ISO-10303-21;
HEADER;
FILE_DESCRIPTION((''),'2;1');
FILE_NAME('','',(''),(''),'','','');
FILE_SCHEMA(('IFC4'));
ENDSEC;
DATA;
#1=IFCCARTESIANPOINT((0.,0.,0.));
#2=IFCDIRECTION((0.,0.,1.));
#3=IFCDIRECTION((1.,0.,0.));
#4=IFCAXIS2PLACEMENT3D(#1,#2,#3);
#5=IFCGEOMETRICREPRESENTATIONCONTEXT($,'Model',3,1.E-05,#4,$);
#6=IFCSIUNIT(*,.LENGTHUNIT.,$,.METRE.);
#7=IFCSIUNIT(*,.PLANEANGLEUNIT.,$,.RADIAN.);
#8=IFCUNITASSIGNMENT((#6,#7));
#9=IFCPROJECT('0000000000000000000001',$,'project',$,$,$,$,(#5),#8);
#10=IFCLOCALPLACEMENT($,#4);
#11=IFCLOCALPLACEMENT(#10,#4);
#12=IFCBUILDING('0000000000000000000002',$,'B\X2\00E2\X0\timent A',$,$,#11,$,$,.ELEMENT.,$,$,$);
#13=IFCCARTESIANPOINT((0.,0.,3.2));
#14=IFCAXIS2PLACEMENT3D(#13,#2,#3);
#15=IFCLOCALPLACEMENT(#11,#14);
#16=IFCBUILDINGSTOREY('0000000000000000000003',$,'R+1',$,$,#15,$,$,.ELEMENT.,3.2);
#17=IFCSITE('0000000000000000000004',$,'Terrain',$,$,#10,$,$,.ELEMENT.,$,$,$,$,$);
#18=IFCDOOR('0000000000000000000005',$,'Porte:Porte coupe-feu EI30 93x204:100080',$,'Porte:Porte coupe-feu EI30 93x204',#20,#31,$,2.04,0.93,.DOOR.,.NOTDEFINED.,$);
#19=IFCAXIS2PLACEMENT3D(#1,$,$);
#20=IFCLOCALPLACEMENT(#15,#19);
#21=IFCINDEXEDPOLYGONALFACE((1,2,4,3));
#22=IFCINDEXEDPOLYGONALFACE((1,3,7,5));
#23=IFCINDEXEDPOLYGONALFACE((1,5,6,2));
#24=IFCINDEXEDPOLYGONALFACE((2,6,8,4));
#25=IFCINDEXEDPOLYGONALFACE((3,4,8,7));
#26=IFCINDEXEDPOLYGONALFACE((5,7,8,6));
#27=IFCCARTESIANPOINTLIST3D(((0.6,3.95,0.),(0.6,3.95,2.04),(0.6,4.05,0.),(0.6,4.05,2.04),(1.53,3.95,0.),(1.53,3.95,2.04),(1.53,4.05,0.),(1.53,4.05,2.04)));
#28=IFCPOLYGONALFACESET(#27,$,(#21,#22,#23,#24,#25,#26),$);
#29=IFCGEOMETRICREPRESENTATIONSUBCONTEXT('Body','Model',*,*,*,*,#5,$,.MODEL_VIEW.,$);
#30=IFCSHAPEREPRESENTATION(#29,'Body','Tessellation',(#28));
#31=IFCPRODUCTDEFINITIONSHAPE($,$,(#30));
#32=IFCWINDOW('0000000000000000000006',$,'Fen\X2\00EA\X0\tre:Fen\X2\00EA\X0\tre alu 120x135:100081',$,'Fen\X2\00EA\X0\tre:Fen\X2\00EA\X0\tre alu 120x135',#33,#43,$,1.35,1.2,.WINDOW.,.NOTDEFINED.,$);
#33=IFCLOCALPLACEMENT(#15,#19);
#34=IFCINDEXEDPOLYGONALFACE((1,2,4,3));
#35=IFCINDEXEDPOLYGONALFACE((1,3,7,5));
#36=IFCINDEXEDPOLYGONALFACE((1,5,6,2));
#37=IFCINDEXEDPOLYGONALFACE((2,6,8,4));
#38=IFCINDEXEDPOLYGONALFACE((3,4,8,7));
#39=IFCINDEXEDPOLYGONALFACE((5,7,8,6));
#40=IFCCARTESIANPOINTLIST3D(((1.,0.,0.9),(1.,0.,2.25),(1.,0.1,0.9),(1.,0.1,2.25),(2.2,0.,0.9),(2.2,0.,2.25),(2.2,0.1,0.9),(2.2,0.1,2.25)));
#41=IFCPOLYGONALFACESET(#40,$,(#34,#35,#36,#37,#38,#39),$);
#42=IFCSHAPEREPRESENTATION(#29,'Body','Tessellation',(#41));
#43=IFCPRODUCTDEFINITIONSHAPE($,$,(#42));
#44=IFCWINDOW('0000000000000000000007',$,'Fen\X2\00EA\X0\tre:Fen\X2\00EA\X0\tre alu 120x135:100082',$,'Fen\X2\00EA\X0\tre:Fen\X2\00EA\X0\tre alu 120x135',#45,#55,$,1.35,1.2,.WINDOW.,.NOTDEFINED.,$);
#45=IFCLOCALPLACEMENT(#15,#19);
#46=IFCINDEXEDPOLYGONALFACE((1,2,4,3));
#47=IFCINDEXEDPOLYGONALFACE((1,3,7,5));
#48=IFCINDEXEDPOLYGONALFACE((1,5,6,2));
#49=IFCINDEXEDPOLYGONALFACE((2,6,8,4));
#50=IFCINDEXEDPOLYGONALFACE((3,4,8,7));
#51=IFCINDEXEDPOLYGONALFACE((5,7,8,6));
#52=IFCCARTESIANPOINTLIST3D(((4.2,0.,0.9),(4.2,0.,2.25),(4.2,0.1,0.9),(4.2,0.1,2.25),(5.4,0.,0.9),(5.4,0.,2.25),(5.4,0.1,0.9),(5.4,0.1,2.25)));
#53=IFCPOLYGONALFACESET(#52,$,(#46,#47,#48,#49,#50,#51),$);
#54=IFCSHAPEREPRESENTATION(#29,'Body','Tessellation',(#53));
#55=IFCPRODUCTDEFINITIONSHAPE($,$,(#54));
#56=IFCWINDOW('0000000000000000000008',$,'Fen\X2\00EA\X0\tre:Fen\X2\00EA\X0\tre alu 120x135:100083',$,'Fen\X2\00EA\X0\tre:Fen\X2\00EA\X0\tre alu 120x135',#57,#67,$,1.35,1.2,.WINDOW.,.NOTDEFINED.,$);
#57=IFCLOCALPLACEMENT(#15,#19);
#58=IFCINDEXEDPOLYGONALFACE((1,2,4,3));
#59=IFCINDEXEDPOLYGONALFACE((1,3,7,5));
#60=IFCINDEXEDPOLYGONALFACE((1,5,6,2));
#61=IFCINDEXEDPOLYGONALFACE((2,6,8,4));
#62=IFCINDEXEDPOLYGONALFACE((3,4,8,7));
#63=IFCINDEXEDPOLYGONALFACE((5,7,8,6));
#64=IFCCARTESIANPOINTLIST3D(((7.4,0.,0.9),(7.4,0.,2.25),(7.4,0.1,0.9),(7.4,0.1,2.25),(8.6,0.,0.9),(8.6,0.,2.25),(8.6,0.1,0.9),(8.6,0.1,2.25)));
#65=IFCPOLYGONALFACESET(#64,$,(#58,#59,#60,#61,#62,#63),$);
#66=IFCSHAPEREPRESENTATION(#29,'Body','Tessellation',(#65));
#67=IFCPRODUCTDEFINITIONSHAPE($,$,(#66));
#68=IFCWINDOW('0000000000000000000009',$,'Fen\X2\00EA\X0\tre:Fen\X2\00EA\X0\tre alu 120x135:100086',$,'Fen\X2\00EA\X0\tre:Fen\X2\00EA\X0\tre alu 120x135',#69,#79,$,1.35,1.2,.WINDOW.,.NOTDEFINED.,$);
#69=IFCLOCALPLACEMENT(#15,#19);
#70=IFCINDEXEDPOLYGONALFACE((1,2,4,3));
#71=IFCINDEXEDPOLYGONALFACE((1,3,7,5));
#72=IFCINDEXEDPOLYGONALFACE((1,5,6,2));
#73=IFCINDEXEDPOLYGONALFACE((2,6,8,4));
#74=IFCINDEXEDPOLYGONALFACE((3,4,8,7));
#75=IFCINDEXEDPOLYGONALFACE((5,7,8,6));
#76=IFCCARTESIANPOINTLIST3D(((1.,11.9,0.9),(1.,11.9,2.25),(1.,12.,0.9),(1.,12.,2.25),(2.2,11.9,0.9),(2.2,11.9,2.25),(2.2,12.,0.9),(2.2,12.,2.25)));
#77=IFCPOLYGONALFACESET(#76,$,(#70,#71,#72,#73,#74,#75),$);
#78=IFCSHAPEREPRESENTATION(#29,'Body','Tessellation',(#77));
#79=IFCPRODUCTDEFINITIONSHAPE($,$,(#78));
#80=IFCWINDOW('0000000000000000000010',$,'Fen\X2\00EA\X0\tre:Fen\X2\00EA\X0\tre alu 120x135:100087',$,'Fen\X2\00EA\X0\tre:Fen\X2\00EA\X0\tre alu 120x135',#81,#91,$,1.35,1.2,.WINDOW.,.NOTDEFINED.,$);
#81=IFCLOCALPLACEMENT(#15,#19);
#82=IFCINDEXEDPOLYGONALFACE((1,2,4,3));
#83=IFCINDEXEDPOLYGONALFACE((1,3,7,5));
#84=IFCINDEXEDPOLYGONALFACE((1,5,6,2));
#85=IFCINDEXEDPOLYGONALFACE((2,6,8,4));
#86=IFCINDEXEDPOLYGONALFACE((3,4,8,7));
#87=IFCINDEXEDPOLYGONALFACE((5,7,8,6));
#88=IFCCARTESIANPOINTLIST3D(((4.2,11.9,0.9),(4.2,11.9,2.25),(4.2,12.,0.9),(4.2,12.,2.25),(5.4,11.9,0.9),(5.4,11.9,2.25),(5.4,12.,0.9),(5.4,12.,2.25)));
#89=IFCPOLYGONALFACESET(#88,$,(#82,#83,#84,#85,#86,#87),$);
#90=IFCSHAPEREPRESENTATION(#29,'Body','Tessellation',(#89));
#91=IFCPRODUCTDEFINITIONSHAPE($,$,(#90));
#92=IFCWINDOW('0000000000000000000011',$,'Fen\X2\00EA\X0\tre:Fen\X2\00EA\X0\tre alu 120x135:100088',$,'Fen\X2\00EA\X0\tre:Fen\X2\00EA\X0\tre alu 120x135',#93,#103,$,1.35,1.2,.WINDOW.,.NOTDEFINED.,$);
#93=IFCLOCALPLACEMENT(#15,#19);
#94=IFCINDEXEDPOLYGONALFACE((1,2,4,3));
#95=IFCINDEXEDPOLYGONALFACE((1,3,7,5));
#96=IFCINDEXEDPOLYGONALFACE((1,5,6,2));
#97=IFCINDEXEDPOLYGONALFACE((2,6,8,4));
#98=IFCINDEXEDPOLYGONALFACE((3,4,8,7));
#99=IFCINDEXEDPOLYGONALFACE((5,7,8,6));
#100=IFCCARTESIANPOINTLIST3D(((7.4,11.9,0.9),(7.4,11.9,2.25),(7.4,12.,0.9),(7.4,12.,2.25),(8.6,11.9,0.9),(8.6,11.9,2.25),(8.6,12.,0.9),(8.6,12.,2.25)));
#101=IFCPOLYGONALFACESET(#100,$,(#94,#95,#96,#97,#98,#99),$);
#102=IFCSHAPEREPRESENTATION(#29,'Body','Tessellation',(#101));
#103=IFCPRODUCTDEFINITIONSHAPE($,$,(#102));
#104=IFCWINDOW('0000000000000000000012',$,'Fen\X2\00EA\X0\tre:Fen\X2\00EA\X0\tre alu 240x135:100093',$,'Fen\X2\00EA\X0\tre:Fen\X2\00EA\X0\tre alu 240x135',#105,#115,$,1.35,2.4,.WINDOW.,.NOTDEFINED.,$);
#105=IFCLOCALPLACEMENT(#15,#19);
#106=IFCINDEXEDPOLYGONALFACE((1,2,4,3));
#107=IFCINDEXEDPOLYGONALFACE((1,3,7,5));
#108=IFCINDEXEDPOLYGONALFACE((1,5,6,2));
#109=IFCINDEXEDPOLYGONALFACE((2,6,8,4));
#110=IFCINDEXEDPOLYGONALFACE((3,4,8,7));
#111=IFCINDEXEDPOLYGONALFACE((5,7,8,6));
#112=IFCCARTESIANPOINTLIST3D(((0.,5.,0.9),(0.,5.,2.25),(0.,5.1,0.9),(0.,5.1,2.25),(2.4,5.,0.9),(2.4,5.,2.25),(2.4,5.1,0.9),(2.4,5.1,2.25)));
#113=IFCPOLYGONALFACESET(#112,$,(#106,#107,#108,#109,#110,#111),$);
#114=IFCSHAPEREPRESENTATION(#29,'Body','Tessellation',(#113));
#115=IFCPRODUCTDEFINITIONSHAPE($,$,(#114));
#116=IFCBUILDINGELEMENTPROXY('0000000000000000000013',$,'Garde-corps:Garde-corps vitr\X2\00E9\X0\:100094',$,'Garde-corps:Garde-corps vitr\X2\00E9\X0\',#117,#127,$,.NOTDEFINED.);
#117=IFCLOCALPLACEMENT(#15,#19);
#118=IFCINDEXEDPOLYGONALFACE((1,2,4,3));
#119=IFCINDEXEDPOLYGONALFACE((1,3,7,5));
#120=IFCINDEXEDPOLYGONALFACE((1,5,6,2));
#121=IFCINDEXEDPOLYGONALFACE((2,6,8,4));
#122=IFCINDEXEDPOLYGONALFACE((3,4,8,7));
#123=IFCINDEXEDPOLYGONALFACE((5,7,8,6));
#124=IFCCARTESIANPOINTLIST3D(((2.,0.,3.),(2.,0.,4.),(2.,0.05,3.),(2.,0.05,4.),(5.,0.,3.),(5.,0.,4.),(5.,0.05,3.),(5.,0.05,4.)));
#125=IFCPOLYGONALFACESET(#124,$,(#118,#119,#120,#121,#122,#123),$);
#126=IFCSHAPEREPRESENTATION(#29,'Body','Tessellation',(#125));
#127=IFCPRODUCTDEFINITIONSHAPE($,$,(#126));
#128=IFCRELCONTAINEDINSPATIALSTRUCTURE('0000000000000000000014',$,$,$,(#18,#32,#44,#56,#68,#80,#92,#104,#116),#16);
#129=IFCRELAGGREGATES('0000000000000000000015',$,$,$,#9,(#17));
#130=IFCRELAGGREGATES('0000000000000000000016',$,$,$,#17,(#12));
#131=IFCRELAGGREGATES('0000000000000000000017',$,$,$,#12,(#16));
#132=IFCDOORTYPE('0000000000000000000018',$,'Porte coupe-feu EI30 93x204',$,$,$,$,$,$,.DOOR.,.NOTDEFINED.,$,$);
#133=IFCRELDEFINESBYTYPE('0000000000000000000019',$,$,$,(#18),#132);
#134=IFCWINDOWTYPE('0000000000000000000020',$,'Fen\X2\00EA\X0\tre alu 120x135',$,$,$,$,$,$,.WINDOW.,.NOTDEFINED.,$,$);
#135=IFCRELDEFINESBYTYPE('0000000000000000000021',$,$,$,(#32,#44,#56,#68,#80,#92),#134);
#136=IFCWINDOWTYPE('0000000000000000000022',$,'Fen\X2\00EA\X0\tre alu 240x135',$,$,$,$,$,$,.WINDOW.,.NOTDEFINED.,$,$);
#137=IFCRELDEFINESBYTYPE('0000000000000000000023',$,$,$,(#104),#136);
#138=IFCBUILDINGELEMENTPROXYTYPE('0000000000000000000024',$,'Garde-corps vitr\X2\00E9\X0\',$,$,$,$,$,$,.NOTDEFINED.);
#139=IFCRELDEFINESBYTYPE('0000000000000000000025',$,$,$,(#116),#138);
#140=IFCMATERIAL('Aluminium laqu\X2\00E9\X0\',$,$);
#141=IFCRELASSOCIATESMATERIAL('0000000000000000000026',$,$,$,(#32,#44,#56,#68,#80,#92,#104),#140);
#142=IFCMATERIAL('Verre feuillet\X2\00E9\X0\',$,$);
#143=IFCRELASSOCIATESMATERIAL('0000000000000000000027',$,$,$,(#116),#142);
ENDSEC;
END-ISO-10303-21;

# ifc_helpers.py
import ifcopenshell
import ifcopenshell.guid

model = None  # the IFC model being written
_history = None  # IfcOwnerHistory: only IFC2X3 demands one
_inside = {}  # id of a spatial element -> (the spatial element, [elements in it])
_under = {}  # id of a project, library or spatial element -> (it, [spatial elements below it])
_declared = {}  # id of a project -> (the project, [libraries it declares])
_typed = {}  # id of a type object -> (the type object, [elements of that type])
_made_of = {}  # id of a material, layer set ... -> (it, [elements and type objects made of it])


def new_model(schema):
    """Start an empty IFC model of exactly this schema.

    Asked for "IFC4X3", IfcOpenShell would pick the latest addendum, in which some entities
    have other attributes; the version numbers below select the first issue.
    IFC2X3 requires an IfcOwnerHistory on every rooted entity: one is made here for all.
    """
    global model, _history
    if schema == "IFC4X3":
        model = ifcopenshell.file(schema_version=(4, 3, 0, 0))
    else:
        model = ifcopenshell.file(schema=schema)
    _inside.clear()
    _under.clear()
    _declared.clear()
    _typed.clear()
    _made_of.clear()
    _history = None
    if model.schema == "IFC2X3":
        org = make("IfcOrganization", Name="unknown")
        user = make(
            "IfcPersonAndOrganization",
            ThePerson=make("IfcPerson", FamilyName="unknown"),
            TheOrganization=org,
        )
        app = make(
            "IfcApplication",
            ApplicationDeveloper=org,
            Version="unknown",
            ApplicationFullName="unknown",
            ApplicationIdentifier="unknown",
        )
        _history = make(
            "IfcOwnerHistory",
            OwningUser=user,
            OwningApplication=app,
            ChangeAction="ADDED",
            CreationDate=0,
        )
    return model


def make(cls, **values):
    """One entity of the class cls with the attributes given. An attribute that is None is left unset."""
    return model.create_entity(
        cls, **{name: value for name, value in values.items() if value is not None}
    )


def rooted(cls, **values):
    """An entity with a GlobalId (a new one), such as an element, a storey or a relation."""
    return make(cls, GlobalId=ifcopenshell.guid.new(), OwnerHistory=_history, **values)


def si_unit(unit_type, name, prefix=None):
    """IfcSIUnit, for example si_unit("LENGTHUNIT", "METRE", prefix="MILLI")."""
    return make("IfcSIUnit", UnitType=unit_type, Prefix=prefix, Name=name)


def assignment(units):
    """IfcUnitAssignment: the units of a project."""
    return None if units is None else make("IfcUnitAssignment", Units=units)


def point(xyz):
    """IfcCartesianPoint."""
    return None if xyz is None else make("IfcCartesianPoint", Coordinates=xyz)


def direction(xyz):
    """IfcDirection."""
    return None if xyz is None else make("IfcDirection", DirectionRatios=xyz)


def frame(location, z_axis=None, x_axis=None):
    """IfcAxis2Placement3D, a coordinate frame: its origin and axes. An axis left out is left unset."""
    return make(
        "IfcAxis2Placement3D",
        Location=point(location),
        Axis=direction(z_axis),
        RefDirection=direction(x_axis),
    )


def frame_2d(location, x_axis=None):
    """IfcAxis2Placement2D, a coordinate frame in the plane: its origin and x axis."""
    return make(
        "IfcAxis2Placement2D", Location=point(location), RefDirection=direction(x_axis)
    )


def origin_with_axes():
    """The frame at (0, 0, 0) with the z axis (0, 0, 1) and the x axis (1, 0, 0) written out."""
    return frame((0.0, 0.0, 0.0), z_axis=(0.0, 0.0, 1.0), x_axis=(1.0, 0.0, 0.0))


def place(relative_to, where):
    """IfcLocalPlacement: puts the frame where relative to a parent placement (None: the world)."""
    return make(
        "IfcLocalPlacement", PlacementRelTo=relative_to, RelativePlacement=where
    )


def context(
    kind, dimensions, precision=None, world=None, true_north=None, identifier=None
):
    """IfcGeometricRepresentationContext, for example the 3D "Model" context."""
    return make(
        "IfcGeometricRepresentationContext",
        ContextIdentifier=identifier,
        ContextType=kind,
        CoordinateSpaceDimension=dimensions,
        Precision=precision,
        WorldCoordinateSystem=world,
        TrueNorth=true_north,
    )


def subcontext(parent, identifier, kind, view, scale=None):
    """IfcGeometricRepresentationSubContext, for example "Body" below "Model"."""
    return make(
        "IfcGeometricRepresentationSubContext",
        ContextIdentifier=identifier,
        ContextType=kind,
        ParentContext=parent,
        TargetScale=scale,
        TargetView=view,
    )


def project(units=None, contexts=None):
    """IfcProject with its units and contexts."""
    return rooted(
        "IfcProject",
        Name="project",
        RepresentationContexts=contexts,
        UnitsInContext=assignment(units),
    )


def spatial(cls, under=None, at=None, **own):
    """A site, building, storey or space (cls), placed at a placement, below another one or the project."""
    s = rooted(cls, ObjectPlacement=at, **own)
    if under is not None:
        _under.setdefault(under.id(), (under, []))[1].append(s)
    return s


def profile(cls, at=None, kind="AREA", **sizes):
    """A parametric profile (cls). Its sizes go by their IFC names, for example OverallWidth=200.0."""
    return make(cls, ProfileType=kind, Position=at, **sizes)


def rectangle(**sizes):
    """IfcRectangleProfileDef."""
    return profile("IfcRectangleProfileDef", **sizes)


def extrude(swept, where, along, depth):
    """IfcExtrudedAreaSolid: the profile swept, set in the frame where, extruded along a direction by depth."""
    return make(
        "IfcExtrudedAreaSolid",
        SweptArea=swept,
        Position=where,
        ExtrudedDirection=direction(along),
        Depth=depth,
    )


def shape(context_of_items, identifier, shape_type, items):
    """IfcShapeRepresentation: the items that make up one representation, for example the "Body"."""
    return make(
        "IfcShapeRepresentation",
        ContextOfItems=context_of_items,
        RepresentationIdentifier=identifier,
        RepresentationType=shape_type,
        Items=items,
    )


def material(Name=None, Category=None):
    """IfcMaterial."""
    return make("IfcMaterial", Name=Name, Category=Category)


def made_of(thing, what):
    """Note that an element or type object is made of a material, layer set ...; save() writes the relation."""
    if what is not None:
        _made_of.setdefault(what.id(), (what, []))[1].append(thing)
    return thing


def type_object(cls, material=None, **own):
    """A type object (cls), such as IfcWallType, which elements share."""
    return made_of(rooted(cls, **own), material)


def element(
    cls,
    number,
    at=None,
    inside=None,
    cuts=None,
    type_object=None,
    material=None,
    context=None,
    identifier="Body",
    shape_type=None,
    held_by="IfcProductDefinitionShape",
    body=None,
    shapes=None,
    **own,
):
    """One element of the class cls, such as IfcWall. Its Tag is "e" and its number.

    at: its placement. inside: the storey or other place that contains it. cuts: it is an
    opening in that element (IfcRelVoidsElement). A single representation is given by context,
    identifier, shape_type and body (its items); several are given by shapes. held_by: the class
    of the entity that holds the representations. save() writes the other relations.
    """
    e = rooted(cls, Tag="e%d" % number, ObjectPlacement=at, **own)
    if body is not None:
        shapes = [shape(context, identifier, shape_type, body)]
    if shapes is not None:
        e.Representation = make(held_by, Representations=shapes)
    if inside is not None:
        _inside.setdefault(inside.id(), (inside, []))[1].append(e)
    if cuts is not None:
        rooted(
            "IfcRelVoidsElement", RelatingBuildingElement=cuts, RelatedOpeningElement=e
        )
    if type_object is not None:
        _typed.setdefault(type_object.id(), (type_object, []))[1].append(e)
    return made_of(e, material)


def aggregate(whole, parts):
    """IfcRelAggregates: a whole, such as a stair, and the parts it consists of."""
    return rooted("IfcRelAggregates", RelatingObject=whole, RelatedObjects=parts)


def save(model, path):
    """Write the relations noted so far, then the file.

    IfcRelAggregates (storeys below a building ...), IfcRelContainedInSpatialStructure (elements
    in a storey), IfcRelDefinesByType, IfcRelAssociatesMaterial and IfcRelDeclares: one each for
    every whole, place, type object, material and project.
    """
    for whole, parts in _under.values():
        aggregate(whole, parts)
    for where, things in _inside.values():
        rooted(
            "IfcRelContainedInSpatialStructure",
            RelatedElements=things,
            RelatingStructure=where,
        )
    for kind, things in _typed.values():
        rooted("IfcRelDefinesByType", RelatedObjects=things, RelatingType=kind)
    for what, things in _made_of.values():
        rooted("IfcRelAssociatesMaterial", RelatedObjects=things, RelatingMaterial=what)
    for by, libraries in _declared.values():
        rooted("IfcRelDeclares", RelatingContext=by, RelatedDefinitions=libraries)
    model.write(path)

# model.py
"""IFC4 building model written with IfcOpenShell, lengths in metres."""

from ifc_helpers import new_model, si_unit, frame, frame_2d, origin_with_axes, place, context, subcontext, project, spatial, rectangle, extrude, material, type_object, element, save


model = new_model("IFC4")

# Units and contexts
model_context = context("Model", 3, precision=1e-05, world=origin_with_axes())
body_context = subcontext(model_context, "Body", "Model", "MODEL_VIEW")
ifc_project = project(units=[si_unit("LENGTHUNIT", "METRE"), si_unit("PLANEANGLEUNIT", "RADIAN")], contexts=[model_context])

# Site, building, storey
site_placement = place(None, origin_with_axes())
site = spatial("IfcSite", under=ifc_project, at=site_placement, Name="Terrain", CompositionType="ELEMENT")
building_placement = place(site_placement, origin_with_axes())
building = spatial("IfcBuilding", under=site, at=building_placement, Name="Bâtiment A", CompositionType="ELEMENT")
storey_placement = place(building_placement, frame((0.0, 0.0, 3.2), z_axis=(0.0, 0.0, 1.0), x_axis=(1.0, 0.0, 0.0)))
storey = spatial("IfcBuildingStorey", under=building, at=storey_placement, Name="R+1", CompositionType="ELEMENT", Elevation=3.2)

# Door
door_type_1 = type_object("IfcDoorType", Name="Porte coupe-feu EI30 93x204", OperationType="NOTDEFINED", PredefinedType="DOOR")
door_placement = place(storey_placement, frame((0.6, 3.95, 0.0), z_axis=(0.0, 0.0, 1.0), x_axis=(1.0, 0.0, 0.0)))
element("IfcDoor", 1, at=door_placement, inside=storey, type_object=door_type_1, Name="Porte:Porte coupe-feu EI30 93x204:100080", ObjectType="Porte:Porte coupe-feu EI30 93x204", OperationType="NOTDEFINED", OverallHeight=2.04, OverallWidth=0.93, PredefinedType="DOOR", context=body_context, shape_type="SweptSolid", body=[
    extrude(rectangle(XDim=0.93, YDim=0.1, at=frame_2d((0.465, 0.05))), origin_with_axes(), (0.0, 0.0, 1.0), 2.04),
])

# Windows
ifc_material_1 = material(Name="Aluminium laqué")
window_type_1 = type_object("IfcWindowType", Name="Fenêtre alu 120x135", PartitioningType="NOTDEFINED", PredefinedType="WINDOW")
for number, where, z_axis, x_axis, name in (
    (2, (1.0, 0.0, 0.9), (0.0, 0.0, 1.0), (1.0, 0.0, 0.0), "Fenêtre:Fenêtre alu 120x135:100081"),
    (3, (4.2, 0.0, 0.9), (0.0, 0.0, 1.0), (1.0, 0.0, 0.0), "Fenêtre:Fenêtre alu 120x135:100082"),
    (4, (7.4, 0.0, 0.9), (0.0, 0.0, 1.0), (1.0, 0.0, 0.0), "Fenêtre:Fenêtre alu 120x135:100083"),
    (5, (1.0, 11.9, 0.9), (0.0, 0.0, 1.0), (1.0, 0.0, 0.0), "Fenêtre:Fenêtre alu 120x135:100086"),
    (6, (4.2, 11.9, 0.9), (0.0, 0.0, 1.0), (1.0, 0.0, 0.0), "Fenêtre:Fenêtre alu 120x135:100087"),
    (7, (7.4, 11.9, 0.9), (0.0, 0.0, 1.0), (1.0, 0.0, 0.0), "Fenêtre:Fenêtre alu 120x135:100088"),
):
    element("IfcWindow", number, at=place(storey_placement, frame(where, z_axis=z_axis, x_axis=x_axis)), inside=storey, type_object=window_type_1, material=ifc_material_1, Name=name, ObjectType="Fenêtre:Fenêtre alu 120x135", OverallHeight=1.35, OverallWidth=1.2, PartitioningType="NOTDEFINED", PredefinedType="WINDOW", context=body_context, shape_type="SweptSolid", body=[
        extrude(rectangle(XDim=1.2, YDim=0.1, at=frame_2d((0.6, 0.05))), origin_with_axes(), (0.0, 0.0, 1.0), 1.35),
    ])
window_type_2 = type_object("IfcWindowType", Name="Fenêtre alu 240x135", PartitioningType="NOTDEFINED", PredefinedType="WINDOW")
window_placement = place(storey_placement, frame((0.0, 5.0, 0.9), z_axis=(0.0, 0.0, 1.0), x_axis=(1.0, 0.0, 0.0)))
element("IfcWindow", 8, at=window_placement, inside=storey, type_object=window_type_2, material=ifc_material_1, Name="Fenêtre:Fenêtre alu 240x135:100093", ObjectType="Fenêtre:Fenêtre alu 240x135", OverallHeight=1.35, OverallWidth=2.4, PartitioningType="NOTDEFINED", PredefinedType="WINDOW", context=body_context, shape_type="SweptSolid", body=[
    extrude(rectangle(XDim=2.4, YDim=0.1, at=frame_2d((1.2, 0.05))), origin_with_axes(), (0.0, 0.0, 1.0), 1.35),
])

# Building element proxy
ifc_material_2 = material(Name="Verre feuilleté")
building_element_proxy_type = type_object("IfcBuildingElementProxyType", Name="Garde-corps vitré", PredefinedType="NOTDEFINED")
proxy_placement = place(storey_placement, frame((2.0, 0.0, 3.0), z_axis=(0.0, 0.0, 1.0), x_axis=(1.0, 0.0, 0.0)))
element("IfcBuildingElementProxy", 9, at=proxy_placement, inside=storey, type_object=building_element_proxy_type, material=ifc_material_2, Name="Garde-corps:Garde-corps vitré:100094", ObjectType="Garde-corps:Garde-corps vitré", PredefinedType="NOTDEFINED", context=body_context, shape_type="SweptSolid", body=[
    extrude(rectangle(XDim=3.0, YDim=0.05, at=frame_2d((1.5, 0.025))), origin_with_axes(), (0.0, 0.0, 1.0), 1.0),
])

save(model, "model.ifc")
